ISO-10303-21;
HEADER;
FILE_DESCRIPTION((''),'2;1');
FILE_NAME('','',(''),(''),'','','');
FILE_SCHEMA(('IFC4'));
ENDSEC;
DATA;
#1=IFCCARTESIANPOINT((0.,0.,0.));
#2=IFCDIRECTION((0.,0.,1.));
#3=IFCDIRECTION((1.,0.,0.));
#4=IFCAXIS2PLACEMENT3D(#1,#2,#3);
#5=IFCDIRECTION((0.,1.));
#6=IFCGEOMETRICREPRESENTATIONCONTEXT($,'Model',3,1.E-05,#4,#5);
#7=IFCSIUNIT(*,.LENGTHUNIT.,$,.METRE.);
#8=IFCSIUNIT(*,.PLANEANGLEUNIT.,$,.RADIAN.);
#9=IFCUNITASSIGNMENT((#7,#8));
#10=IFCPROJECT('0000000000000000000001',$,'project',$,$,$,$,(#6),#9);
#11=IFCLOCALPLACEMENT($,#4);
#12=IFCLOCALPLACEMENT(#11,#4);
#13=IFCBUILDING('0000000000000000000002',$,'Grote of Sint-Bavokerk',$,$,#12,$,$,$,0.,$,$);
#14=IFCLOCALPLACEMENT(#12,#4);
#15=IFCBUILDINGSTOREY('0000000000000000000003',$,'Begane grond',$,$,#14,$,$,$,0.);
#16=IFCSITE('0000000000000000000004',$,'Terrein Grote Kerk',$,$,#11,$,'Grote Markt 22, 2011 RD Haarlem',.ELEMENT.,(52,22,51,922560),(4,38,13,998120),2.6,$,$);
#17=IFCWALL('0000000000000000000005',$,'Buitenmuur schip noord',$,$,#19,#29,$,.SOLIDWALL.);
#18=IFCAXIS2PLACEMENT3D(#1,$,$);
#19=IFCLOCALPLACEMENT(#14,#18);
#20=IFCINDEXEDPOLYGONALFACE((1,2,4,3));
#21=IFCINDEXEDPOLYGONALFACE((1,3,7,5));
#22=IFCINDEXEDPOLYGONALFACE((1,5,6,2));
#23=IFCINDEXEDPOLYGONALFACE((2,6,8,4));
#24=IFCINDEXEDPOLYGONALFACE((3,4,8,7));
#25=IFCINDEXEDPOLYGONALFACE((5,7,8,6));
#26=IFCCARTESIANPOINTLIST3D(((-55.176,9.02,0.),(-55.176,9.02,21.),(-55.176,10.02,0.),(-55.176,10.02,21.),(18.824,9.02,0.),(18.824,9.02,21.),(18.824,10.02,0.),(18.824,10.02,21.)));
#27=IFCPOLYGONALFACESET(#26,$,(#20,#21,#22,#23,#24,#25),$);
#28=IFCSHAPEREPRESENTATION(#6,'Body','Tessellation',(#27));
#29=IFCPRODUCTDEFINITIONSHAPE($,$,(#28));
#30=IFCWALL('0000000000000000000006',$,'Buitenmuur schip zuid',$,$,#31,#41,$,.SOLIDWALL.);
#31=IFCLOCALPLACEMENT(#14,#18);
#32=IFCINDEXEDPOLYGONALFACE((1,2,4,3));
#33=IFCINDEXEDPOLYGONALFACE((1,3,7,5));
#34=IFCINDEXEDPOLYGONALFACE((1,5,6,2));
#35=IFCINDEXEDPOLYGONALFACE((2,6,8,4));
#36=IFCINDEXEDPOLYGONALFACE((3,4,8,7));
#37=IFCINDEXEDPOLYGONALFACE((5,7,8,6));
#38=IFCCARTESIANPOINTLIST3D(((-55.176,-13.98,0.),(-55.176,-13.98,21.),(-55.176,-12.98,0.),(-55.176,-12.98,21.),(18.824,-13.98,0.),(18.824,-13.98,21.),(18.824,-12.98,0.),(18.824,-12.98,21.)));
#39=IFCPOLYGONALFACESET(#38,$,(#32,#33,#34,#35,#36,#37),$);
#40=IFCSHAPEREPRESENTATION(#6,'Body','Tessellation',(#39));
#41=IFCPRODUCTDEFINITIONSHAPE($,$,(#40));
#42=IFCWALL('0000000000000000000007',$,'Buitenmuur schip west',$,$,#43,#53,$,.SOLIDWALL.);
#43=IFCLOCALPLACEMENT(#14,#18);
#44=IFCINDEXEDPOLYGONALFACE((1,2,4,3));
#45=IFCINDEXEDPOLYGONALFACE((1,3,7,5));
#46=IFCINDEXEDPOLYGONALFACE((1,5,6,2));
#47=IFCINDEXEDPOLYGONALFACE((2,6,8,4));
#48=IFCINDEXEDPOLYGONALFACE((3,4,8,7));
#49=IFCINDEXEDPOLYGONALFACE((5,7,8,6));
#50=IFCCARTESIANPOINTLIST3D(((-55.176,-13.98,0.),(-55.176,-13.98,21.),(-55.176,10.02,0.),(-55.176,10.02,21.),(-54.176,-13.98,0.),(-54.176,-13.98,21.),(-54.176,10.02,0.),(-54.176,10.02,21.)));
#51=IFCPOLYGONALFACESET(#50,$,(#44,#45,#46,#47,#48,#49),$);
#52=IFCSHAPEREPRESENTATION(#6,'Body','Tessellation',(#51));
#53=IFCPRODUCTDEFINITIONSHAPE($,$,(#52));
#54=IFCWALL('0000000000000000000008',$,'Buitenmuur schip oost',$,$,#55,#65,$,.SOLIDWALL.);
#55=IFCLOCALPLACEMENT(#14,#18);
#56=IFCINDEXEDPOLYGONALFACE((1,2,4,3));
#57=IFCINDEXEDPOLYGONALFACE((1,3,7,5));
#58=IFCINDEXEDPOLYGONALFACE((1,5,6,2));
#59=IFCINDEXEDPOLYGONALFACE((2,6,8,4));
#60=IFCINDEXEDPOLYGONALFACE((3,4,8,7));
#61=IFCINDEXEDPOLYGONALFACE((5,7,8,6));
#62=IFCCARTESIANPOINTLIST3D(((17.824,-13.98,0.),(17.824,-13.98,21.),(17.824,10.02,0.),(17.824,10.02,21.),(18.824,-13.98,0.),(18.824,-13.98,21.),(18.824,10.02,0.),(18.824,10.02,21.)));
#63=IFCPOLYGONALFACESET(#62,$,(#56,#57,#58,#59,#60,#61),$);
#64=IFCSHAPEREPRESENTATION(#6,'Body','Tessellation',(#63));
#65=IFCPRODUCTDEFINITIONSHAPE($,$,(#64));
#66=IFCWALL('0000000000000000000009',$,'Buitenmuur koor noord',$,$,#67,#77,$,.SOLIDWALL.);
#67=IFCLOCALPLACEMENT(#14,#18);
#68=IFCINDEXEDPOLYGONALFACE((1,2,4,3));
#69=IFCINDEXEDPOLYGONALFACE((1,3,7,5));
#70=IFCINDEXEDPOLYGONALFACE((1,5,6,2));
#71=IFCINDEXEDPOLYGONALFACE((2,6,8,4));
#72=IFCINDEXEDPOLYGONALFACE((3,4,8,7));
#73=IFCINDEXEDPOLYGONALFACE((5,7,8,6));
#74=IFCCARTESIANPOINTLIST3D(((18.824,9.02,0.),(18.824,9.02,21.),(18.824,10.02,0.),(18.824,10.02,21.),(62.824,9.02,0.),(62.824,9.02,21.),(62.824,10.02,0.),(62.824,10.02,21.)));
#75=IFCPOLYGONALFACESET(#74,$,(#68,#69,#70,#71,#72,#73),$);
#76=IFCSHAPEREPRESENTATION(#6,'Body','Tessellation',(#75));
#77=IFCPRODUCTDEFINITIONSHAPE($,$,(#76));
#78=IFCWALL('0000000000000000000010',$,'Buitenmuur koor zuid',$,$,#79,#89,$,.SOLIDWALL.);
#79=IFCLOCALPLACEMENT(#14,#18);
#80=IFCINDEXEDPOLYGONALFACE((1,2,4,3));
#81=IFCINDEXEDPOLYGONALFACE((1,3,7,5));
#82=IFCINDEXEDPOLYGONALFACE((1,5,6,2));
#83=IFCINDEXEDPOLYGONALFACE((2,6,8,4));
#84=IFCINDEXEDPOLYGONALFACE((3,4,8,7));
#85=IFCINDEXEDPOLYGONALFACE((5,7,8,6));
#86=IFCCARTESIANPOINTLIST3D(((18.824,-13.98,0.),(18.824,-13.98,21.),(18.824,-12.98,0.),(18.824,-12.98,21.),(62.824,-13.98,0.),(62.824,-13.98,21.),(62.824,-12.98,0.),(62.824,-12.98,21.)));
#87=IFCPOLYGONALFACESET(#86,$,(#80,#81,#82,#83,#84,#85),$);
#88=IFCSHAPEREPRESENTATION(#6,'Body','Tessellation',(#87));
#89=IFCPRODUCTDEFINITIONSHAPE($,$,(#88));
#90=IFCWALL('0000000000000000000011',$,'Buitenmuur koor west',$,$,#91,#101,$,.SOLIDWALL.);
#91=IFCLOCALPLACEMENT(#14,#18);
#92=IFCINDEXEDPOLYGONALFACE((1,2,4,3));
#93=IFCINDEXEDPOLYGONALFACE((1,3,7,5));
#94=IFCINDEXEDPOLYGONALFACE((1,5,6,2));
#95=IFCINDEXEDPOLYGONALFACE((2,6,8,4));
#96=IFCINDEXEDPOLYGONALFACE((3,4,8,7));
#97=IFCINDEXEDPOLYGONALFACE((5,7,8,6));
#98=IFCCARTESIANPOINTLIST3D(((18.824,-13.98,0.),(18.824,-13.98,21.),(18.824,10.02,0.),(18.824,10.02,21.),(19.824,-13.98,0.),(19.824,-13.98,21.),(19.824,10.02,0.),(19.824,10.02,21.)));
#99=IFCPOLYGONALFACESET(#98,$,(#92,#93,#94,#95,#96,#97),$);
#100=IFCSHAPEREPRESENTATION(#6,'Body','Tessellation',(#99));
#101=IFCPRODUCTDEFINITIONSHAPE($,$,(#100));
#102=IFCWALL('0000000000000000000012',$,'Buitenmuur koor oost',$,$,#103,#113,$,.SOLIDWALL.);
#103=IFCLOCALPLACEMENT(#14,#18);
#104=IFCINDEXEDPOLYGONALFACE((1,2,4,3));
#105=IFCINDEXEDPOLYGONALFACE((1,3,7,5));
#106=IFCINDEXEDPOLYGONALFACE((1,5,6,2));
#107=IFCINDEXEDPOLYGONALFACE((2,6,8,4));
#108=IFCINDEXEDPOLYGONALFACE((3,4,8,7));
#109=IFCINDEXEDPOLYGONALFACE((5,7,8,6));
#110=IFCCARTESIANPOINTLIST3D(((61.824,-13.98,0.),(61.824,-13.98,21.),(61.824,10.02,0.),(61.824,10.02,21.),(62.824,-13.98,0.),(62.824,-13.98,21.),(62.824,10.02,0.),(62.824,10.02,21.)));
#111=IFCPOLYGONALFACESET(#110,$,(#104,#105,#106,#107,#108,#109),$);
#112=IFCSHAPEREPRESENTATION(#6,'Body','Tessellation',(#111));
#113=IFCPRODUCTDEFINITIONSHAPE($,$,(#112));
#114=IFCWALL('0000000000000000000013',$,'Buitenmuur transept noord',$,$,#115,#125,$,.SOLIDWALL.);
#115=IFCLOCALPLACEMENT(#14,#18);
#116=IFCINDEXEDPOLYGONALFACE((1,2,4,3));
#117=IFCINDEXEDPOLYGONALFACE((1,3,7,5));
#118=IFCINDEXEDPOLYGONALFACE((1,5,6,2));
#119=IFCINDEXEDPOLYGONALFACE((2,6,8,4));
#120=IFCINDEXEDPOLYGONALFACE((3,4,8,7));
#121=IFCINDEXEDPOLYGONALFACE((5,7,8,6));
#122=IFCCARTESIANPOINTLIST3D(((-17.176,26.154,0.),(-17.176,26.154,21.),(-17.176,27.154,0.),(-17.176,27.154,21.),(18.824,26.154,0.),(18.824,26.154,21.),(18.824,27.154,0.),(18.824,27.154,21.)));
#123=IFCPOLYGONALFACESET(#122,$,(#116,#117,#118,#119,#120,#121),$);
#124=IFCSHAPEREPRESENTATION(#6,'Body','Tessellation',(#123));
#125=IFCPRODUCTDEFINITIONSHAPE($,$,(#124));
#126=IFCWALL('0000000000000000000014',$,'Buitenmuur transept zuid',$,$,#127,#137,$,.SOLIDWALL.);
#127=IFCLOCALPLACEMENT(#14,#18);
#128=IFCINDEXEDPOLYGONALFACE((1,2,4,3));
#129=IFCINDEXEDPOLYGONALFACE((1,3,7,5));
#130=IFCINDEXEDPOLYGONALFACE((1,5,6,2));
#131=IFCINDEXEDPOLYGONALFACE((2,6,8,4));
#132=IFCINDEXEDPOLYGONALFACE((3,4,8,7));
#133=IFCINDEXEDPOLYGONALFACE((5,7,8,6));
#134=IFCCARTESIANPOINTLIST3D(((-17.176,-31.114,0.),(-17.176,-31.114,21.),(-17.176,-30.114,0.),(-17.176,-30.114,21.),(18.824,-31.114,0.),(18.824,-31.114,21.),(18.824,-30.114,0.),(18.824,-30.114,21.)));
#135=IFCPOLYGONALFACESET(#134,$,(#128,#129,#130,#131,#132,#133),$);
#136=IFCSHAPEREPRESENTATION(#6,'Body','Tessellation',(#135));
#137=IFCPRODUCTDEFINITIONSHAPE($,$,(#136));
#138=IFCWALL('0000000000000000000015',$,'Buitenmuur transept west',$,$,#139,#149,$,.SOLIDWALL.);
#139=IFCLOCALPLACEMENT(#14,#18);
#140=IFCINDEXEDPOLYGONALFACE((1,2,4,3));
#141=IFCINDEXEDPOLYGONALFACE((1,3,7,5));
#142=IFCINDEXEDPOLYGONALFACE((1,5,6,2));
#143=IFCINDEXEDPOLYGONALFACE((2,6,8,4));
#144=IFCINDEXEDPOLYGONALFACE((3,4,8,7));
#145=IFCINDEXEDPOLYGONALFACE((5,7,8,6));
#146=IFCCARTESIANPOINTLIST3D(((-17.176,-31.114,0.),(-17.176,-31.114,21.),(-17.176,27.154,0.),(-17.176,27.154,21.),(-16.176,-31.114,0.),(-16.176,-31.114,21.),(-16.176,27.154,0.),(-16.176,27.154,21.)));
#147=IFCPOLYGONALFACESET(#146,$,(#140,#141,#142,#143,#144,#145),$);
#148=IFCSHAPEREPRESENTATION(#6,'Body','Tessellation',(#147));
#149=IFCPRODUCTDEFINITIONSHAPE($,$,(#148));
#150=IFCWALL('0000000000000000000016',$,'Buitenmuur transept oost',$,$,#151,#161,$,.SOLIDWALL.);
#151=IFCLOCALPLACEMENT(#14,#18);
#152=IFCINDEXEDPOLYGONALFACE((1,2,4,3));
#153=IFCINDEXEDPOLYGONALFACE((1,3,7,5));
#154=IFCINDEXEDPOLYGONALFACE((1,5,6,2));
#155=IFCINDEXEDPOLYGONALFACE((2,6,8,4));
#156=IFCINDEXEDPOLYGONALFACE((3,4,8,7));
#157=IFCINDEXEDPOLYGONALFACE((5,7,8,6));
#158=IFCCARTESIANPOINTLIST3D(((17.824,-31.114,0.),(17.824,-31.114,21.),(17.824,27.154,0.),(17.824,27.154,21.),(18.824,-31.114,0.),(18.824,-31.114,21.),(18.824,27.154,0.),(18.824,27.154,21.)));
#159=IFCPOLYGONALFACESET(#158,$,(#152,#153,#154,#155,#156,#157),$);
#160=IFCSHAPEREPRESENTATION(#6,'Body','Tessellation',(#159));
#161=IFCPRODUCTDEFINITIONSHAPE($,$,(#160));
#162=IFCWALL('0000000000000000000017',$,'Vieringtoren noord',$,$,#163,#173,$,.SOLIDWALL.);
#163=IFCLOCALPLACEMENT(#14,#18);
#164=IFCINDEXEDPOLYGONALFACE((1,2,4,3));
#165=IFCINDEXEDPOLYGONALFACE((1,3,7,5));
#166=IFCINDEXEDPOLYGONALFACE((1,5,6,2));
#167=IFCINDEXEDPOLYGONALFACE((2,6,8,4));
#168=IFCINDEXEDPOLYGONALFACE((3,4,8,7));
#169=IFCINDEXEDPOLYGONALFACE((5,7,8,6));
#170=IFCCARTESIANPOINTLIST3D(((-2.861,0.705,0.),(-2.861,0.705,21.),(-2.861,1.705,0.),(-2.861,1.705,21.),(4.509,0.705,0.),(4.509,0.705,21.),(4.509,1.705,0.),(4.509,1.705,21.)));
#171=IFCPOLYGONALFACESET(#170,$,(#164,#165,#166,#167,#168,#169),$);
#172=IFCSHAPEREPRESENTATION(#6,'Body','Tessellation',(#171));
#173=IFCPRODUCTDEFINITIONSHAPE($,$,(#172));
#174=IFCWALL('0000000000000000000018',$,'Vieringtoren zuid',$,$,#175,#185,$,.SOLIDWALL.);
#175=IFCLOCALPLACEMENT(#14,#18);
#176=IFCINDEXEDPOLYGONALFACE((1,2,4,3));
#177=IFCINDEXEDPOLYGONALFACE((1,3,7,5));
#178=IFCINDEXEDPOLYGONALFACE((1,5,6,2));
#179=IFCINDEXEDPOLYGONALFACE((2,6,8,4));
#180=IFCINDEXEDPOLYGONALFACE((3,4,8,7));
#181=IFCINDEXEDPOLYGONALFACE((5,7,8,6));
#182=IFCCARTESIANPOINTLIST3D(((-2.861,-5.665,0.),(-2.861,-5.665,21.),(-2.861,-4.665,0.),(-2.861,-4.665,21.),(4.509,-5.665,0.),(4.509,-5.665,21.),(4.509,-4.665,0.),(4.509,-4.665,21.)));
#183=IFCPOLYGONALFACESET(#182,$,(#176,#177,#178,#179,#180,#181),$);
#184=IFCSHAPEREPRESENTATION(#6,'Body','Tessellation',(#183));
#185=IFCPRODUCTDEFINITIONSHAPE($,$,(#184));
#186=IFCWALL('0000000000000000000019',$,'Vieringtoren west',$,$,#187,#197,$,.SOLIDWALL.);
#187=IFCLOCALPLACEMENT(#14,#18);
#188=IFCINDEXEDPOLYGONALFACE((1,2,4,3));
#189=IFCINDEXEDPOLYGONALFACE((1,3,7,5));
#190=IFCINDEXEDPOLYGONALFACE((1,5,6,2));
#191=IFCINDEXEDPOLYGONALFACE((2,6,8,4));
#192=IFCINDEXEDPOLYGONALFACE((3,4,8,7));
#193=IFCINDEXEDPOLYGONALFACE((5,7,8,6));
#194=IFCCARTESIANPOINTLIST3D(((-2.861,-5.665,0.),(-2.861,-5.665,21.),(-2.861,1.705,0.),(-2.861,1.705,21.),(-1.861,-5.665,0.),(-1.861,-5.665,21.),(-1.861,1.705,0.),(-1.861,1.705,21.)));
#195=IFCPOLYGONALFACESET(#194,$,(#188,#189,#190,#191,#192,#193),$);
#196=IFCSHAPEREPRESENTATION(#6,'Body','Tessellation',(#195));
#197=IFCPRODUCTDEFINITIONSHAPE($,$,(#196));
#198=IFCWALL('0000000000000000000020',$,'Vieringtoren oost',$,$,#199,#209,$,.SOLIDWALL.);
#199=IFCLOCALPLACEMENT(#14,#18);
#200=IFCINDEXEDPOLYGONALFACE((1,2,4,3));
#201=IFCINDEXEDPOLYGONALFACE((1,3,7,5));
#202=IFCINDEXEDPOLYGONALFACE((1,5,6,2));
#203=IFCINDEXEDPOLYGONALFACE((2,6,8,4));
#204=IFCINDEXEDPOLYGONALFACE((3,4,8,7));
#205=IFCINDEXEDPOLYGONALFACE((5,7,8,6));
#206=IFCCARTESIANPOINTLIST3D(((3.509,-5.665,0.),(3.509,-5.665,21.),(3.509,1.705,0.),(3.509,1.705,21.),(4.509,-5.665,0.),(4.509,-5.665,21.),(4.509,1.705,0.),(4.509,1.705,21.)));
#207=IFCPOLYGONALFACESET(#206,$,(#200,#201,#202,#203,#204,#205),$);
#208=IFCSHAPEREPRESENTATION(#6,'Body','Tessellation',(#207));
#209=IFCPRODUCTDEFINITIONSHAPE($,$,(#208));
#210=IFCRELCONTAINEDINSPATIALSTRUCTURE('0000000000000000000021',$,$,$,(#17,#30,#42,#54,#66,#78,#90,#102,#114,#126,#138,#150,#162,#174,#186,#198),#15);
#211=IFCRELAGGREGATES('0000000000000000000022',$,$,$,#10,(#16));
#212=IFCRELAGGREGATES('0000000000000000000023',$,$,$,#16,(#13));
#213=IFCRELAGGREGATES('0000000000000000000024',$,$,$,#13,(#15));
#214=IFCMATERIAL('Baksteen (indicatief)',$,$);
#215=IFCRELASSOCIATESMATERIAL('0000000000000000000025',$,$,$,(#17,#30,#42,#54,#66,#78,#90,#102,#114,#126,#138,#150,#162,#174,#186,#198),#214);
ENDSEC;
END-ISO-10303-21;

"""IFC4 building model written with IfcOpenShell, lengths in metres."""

from ifc_helpers import new_model, si_unit, direction, origin_with_axes, place, context, project, spatial, indexed_curve, outline, extrude, material, element, save


model = new_model("IFC4")

# Units and contexts
model_context = context("Model", 3, precision=1e-05, world=origin_with_axes(), true_north=direction((0.0, 1.0)))
ifc_project = project(units=[si_unit("LENGTHUNIT", "METRE"), si_unit("PLANEANGLEUNIT", "RADIAN")], contexts=[model_context])

# Site, building, storey
site_placement = place(None, origin_with_axes())
site = spatial("IfcSite", under=ifc_project, at=site_placement, Name="Terrein Grote Kerk", LongName="Grote Markt 22, 2011 RD Haarlem", CompositionType="ELEMENT", RefLatitude=(52, 22, 51, 922560), RefLongitude=(4, 38, 13, 998120), RefElevation=2.6)
building_placement = place(site_placement, origin_with_axes())
building = spatial("IfcBuilding", under=site, at=building_placement, Name="Grote of Sint-Bavokerk", ElevationOfRefHeight=0.0)
storey_placement = place(building_placement, origin_with_axes())
storey = spatial("IfcBuildingStorey", under=building, at=storey_placement, Name="Begane grond", Elevation=0.0)

# Shared definitions
ifc_material = material(Name="Baksteen (indicatief)")

# Walls
wall_1_placement = place(storey_placement, origin_with_axes())
element("IfcWall", 1, at=wall_1_placement, inside=storey, material=ifc_material, Name="Buitenmuur schip noord", PredefinedType="SOLIDWALL", context=model_context, shape_type="SweptSolid", body=[
    extrude(outline(indexed_curve([(-55.176, 9.02), (18.824, 9.02), (18.824, 10.02), (-55.176, 10.02), (-55.176, 9.02)])), origin_with_axes(), (0.0, 0.0, 1.0), 21.0),
])
wall_2_placement = place(storey_placement, origin_with_axes())
element("IfcWall", 2, at=wall_2_placement, inside=storey, material=ifc_material, Name="Buitenmuur schip zuid", PredefinedType="SOLIDWALL", context=model_context, shape_type="SweptSolid", body=[
    extrude(outline(indexed_curve([(-55.176, -13.98), (18.824, -13.98), (18.824, -12.98), (-55.176, -12.98), (-55.176, -13.98)])), origin_with_axes(), (0.0, 0.0, 1.0), 21.0),
])
wall_3_placement = place(storey_placement, origin_with_axes())
element("IfcWall", 3, at=wall_3_placement, inside=storey, material=ifc_material, Name="Buitenmuur schip west", PredefinedType="SOLIDWALL", context=model_context, shape_type="SweptSolid", body=[
    extrude(outline(indexed_curve([(-55.176, -13.98), (-54.176, -13.98), (-54.176, 10.02), (-55.176, 10.02), (-55.176, -13.98)])), origin_with_axes(), (0.0, 0.0, 1.0), 21.0),
])
wall_4_placement = place(storey_placement, origin_with_axes())
element("IfcWall", 4, at=wall_4_placement, inside=storey, material=ifc_material, Name="Buitenmuur schip oost", PredefinedType="SOLIDWALL", context=model_context, shape_type="SweptSolid", body=[
    extrude(outline(indexed_curve([(17.824, -13.98), (18.824, -13.98), (18.824, 10.02), (17.824, 10.02), (17.824, -13.98)])), origin_with_axes(), (0.0, 0.0, 1.0), 21.0),
])
wall_5_placement = place(storey_placement, origin_with_axes())
element("IfcWall", 5, at=wall_5_placement, inside=storey, material=ifc_material, Name="Buitenmuur koor noord", PredefinedType="SOLIDWALL", context=model_context, shape_type="SweptSolid", body=[
    extrude(outline(indexed_curve([(18.824, 9.02), (62.824, 9.02), (62.824, 10.02), (18.824, 10.02), (18.824, 9.02)])), origin_with_axes(), (0.0, 0.0, 1.0), 21.0),
])
wall_6_placement = place(storey_placement, origin_with_axes())
element("IfcWall", 6, at=wall_6_placement, inside=storey, material=ifc_material, Name="Buitenmuur koor zuid", PredefinedType="SOLIDWALL", context=model_context, shape_type="SweptSolid", body=[
    extrude(outline(indexed_curve([(18.824, -13.98), (62.824, -13.98), (62.824, -12.98), (18.824, -12.98), (18.824, -13.98)])), origin_with_axes(), (0.0, 0.0, 1.0), 21.0),
])
wall_7_placement = place(storey_placement, origin_with_axes())
element("IfcWall", 7, at=wall_7_placement, inside=storey, material=ifc_material, Name="Buitenmuur koor west", PredefinedType="SOLIDWALL", context=model_context, shape_type="SweptSolid", body=[
    extrude(outline(indexed_curve([(18.824, -13.98), (19.824, -13.98), (19.824, 10.02), (18.824, 10.02), (18.824, -13.98)])), origin_with_axes(), (0.0, 0.0, 1.0), 21.0),
])
wall_8_placement = place(storey_placement, origin_with_axes())
element("IfcWall", 8, at=wall_8_placement, inside=storey, material=ifc_material, Name="Buitenmuur koor oost", PredefinedType="SOLIDWALL", context=model_context, shape_type="SweptSolid", body=[
    extrude(outline(indexed_curve([(61.824, -13.98), (62.824, -13.98), (62.824, 10.02), (61.824, 10.02), (61.824, -13.98)])), origin_with_axes(), (0.0, 0.0, 1.0), 21.0),
])
wall_9_placement = place(storey_placement, origin_with_axes())
element("IfcWall", 9, at=wall_9_placement, inside=storey, material=ifc_material, Name="Buitenmuur transept noord", PredefinedType="SOLIDWALL", context=model_context, shape_type="SweptSolid", body=[
    extrude(outline(indexed_curve([(-17.176, 26.154), (18.824, 26.154), (18.824, 27.154), (-17.176, 27.154), (-17.176, 26.154)])), origin_with_axes(), (0.0, 0.0, 1.0), 21.0),
])
wall_10_placement = place(storey_placement, origin_with_axes())
element("IfcWall", 10, at=wall_10_placement, inside=storey, material=ifc_material, Name="Buitenmuur transept zuid", PredefinedType="SOLIDWALL", context=model_context, shape_type="SweptSolid", body=[
    extrude(outline(indexed_curve([(-17.176, -31.114), (18.824, -31.114), (18.824, -30.114), (-17.176, -30.114), (-17.176, -31.114)])), origin_with_axes(), (0.0, 0.0, 1.0), 21.0),
])
wall_11_placement = place(storey_placement, origin_with_axes())
element("IfcWall", 11, at=wall_11_placement, inside=storey, material=ifc_material, Name="Buitenmuur transept west", PredefinedType="SOLIDWALL", context=model_context, shape_type="SweptSolid", body=[
    extrude(outline(indexed_curve([(-17.176, -31.114), (-16.176, -31.114), (-16.176, 27.154), (-17.176, 27.154), (-17.176, -31.114)])), origin_with_axes(), (0.0, 0.0, 1.0), 21.0),
])
wall_12_placement = place(storey_placement, origin_with_axes())
element("IfcWall", 12, at=wall_12_placement, inside=storey, material=ifc_material, Name="Buitenmuur transept oost", PredefinedType="SOLIDWALL", context=model_context, shape_type="SweptSolid", body=[
    extrude(outline(indexed_curve([(17.824, -31.114), (18.824, -31.114), (18.824, 27.154), (17.824, 27.154), (17.824, -31.114)])), origin_with_axes(), (0.0, 0.0, 1.0), 21.0),
])
wall_13_placement = place(storey_placement, origin_with_axes())
element("IfcWall", 13, at=wall_13_placement, inside=storey, material=ifc_material, Name="Vieringtoren noord", PredefinedType="SOLIDWALL", context=model_context, shape_type="SweptSolid", body=[
    extrude(outline(indexed_curve([(-2.861, 0.705), (4.509, 0.705), (4.509, 1.705), (-2.861, 1.705), (-2.861, 0.705)])), origin_with_axes(), (0.0, 0.0, 1.0), 21.0),
])
wall_14_placement = place(storey_placement, origin_with_axes())
element("IfcWall", 14, at=wall_14_placement, inside=storey, material=ifc_material, Name="Vieringtoren zuid", PredefinedType="SOLIDWALL", context=model_context, shape_type="SweptSolid", body=[
    extrude(outline(indexed_curve([(-2.861, -5.665), (4.509, -5.665), (4.509, -4.665), (-2.861, -4.665), (-2.861, -5.665)])), origin_with_axes(), (0.0, 0.0, 1.0), 21.0),
])
wall_15_placement = place(storey_placement, origin_with_axes())
element("IfcWall", 15, at=wall_15_placement, inside=storey, material=ifc_material, Name="Vieringtoren west", PredefinedType="SOLIDWALL", context=model_context, shape_type="SweptSolid", body=[
    extrude(outline(indexed_curve([(-2.861, -5.665), (-1.861, -5.665), (-1.861, 1.705), (-2.861, 1.705), (-2.861, -5.665)])), origin_with_axes(), (0.0, 0.0, 1.0), 21.0),
])
wall_16_placement = place(storey_placement, origin_with_axes())
element("IfcWall", 16, at=wall_16_placement, inside=storey, material=ifc_material, Name="Vieringtoren oost", PredefinedType="SOLIDWALL", context=model_context, shape_type="SweptSolid", body=[
    extrude(outline(indexed_curve([(3.509, -5.665), (4.509, -5.665), (4.509, 1.705), (3.509, 1.705), (3.509, -5.665)])), origin_with_axes(), (0.0, 0.0, 1.0), 21.0),
])

save(model, "model.ifc")
